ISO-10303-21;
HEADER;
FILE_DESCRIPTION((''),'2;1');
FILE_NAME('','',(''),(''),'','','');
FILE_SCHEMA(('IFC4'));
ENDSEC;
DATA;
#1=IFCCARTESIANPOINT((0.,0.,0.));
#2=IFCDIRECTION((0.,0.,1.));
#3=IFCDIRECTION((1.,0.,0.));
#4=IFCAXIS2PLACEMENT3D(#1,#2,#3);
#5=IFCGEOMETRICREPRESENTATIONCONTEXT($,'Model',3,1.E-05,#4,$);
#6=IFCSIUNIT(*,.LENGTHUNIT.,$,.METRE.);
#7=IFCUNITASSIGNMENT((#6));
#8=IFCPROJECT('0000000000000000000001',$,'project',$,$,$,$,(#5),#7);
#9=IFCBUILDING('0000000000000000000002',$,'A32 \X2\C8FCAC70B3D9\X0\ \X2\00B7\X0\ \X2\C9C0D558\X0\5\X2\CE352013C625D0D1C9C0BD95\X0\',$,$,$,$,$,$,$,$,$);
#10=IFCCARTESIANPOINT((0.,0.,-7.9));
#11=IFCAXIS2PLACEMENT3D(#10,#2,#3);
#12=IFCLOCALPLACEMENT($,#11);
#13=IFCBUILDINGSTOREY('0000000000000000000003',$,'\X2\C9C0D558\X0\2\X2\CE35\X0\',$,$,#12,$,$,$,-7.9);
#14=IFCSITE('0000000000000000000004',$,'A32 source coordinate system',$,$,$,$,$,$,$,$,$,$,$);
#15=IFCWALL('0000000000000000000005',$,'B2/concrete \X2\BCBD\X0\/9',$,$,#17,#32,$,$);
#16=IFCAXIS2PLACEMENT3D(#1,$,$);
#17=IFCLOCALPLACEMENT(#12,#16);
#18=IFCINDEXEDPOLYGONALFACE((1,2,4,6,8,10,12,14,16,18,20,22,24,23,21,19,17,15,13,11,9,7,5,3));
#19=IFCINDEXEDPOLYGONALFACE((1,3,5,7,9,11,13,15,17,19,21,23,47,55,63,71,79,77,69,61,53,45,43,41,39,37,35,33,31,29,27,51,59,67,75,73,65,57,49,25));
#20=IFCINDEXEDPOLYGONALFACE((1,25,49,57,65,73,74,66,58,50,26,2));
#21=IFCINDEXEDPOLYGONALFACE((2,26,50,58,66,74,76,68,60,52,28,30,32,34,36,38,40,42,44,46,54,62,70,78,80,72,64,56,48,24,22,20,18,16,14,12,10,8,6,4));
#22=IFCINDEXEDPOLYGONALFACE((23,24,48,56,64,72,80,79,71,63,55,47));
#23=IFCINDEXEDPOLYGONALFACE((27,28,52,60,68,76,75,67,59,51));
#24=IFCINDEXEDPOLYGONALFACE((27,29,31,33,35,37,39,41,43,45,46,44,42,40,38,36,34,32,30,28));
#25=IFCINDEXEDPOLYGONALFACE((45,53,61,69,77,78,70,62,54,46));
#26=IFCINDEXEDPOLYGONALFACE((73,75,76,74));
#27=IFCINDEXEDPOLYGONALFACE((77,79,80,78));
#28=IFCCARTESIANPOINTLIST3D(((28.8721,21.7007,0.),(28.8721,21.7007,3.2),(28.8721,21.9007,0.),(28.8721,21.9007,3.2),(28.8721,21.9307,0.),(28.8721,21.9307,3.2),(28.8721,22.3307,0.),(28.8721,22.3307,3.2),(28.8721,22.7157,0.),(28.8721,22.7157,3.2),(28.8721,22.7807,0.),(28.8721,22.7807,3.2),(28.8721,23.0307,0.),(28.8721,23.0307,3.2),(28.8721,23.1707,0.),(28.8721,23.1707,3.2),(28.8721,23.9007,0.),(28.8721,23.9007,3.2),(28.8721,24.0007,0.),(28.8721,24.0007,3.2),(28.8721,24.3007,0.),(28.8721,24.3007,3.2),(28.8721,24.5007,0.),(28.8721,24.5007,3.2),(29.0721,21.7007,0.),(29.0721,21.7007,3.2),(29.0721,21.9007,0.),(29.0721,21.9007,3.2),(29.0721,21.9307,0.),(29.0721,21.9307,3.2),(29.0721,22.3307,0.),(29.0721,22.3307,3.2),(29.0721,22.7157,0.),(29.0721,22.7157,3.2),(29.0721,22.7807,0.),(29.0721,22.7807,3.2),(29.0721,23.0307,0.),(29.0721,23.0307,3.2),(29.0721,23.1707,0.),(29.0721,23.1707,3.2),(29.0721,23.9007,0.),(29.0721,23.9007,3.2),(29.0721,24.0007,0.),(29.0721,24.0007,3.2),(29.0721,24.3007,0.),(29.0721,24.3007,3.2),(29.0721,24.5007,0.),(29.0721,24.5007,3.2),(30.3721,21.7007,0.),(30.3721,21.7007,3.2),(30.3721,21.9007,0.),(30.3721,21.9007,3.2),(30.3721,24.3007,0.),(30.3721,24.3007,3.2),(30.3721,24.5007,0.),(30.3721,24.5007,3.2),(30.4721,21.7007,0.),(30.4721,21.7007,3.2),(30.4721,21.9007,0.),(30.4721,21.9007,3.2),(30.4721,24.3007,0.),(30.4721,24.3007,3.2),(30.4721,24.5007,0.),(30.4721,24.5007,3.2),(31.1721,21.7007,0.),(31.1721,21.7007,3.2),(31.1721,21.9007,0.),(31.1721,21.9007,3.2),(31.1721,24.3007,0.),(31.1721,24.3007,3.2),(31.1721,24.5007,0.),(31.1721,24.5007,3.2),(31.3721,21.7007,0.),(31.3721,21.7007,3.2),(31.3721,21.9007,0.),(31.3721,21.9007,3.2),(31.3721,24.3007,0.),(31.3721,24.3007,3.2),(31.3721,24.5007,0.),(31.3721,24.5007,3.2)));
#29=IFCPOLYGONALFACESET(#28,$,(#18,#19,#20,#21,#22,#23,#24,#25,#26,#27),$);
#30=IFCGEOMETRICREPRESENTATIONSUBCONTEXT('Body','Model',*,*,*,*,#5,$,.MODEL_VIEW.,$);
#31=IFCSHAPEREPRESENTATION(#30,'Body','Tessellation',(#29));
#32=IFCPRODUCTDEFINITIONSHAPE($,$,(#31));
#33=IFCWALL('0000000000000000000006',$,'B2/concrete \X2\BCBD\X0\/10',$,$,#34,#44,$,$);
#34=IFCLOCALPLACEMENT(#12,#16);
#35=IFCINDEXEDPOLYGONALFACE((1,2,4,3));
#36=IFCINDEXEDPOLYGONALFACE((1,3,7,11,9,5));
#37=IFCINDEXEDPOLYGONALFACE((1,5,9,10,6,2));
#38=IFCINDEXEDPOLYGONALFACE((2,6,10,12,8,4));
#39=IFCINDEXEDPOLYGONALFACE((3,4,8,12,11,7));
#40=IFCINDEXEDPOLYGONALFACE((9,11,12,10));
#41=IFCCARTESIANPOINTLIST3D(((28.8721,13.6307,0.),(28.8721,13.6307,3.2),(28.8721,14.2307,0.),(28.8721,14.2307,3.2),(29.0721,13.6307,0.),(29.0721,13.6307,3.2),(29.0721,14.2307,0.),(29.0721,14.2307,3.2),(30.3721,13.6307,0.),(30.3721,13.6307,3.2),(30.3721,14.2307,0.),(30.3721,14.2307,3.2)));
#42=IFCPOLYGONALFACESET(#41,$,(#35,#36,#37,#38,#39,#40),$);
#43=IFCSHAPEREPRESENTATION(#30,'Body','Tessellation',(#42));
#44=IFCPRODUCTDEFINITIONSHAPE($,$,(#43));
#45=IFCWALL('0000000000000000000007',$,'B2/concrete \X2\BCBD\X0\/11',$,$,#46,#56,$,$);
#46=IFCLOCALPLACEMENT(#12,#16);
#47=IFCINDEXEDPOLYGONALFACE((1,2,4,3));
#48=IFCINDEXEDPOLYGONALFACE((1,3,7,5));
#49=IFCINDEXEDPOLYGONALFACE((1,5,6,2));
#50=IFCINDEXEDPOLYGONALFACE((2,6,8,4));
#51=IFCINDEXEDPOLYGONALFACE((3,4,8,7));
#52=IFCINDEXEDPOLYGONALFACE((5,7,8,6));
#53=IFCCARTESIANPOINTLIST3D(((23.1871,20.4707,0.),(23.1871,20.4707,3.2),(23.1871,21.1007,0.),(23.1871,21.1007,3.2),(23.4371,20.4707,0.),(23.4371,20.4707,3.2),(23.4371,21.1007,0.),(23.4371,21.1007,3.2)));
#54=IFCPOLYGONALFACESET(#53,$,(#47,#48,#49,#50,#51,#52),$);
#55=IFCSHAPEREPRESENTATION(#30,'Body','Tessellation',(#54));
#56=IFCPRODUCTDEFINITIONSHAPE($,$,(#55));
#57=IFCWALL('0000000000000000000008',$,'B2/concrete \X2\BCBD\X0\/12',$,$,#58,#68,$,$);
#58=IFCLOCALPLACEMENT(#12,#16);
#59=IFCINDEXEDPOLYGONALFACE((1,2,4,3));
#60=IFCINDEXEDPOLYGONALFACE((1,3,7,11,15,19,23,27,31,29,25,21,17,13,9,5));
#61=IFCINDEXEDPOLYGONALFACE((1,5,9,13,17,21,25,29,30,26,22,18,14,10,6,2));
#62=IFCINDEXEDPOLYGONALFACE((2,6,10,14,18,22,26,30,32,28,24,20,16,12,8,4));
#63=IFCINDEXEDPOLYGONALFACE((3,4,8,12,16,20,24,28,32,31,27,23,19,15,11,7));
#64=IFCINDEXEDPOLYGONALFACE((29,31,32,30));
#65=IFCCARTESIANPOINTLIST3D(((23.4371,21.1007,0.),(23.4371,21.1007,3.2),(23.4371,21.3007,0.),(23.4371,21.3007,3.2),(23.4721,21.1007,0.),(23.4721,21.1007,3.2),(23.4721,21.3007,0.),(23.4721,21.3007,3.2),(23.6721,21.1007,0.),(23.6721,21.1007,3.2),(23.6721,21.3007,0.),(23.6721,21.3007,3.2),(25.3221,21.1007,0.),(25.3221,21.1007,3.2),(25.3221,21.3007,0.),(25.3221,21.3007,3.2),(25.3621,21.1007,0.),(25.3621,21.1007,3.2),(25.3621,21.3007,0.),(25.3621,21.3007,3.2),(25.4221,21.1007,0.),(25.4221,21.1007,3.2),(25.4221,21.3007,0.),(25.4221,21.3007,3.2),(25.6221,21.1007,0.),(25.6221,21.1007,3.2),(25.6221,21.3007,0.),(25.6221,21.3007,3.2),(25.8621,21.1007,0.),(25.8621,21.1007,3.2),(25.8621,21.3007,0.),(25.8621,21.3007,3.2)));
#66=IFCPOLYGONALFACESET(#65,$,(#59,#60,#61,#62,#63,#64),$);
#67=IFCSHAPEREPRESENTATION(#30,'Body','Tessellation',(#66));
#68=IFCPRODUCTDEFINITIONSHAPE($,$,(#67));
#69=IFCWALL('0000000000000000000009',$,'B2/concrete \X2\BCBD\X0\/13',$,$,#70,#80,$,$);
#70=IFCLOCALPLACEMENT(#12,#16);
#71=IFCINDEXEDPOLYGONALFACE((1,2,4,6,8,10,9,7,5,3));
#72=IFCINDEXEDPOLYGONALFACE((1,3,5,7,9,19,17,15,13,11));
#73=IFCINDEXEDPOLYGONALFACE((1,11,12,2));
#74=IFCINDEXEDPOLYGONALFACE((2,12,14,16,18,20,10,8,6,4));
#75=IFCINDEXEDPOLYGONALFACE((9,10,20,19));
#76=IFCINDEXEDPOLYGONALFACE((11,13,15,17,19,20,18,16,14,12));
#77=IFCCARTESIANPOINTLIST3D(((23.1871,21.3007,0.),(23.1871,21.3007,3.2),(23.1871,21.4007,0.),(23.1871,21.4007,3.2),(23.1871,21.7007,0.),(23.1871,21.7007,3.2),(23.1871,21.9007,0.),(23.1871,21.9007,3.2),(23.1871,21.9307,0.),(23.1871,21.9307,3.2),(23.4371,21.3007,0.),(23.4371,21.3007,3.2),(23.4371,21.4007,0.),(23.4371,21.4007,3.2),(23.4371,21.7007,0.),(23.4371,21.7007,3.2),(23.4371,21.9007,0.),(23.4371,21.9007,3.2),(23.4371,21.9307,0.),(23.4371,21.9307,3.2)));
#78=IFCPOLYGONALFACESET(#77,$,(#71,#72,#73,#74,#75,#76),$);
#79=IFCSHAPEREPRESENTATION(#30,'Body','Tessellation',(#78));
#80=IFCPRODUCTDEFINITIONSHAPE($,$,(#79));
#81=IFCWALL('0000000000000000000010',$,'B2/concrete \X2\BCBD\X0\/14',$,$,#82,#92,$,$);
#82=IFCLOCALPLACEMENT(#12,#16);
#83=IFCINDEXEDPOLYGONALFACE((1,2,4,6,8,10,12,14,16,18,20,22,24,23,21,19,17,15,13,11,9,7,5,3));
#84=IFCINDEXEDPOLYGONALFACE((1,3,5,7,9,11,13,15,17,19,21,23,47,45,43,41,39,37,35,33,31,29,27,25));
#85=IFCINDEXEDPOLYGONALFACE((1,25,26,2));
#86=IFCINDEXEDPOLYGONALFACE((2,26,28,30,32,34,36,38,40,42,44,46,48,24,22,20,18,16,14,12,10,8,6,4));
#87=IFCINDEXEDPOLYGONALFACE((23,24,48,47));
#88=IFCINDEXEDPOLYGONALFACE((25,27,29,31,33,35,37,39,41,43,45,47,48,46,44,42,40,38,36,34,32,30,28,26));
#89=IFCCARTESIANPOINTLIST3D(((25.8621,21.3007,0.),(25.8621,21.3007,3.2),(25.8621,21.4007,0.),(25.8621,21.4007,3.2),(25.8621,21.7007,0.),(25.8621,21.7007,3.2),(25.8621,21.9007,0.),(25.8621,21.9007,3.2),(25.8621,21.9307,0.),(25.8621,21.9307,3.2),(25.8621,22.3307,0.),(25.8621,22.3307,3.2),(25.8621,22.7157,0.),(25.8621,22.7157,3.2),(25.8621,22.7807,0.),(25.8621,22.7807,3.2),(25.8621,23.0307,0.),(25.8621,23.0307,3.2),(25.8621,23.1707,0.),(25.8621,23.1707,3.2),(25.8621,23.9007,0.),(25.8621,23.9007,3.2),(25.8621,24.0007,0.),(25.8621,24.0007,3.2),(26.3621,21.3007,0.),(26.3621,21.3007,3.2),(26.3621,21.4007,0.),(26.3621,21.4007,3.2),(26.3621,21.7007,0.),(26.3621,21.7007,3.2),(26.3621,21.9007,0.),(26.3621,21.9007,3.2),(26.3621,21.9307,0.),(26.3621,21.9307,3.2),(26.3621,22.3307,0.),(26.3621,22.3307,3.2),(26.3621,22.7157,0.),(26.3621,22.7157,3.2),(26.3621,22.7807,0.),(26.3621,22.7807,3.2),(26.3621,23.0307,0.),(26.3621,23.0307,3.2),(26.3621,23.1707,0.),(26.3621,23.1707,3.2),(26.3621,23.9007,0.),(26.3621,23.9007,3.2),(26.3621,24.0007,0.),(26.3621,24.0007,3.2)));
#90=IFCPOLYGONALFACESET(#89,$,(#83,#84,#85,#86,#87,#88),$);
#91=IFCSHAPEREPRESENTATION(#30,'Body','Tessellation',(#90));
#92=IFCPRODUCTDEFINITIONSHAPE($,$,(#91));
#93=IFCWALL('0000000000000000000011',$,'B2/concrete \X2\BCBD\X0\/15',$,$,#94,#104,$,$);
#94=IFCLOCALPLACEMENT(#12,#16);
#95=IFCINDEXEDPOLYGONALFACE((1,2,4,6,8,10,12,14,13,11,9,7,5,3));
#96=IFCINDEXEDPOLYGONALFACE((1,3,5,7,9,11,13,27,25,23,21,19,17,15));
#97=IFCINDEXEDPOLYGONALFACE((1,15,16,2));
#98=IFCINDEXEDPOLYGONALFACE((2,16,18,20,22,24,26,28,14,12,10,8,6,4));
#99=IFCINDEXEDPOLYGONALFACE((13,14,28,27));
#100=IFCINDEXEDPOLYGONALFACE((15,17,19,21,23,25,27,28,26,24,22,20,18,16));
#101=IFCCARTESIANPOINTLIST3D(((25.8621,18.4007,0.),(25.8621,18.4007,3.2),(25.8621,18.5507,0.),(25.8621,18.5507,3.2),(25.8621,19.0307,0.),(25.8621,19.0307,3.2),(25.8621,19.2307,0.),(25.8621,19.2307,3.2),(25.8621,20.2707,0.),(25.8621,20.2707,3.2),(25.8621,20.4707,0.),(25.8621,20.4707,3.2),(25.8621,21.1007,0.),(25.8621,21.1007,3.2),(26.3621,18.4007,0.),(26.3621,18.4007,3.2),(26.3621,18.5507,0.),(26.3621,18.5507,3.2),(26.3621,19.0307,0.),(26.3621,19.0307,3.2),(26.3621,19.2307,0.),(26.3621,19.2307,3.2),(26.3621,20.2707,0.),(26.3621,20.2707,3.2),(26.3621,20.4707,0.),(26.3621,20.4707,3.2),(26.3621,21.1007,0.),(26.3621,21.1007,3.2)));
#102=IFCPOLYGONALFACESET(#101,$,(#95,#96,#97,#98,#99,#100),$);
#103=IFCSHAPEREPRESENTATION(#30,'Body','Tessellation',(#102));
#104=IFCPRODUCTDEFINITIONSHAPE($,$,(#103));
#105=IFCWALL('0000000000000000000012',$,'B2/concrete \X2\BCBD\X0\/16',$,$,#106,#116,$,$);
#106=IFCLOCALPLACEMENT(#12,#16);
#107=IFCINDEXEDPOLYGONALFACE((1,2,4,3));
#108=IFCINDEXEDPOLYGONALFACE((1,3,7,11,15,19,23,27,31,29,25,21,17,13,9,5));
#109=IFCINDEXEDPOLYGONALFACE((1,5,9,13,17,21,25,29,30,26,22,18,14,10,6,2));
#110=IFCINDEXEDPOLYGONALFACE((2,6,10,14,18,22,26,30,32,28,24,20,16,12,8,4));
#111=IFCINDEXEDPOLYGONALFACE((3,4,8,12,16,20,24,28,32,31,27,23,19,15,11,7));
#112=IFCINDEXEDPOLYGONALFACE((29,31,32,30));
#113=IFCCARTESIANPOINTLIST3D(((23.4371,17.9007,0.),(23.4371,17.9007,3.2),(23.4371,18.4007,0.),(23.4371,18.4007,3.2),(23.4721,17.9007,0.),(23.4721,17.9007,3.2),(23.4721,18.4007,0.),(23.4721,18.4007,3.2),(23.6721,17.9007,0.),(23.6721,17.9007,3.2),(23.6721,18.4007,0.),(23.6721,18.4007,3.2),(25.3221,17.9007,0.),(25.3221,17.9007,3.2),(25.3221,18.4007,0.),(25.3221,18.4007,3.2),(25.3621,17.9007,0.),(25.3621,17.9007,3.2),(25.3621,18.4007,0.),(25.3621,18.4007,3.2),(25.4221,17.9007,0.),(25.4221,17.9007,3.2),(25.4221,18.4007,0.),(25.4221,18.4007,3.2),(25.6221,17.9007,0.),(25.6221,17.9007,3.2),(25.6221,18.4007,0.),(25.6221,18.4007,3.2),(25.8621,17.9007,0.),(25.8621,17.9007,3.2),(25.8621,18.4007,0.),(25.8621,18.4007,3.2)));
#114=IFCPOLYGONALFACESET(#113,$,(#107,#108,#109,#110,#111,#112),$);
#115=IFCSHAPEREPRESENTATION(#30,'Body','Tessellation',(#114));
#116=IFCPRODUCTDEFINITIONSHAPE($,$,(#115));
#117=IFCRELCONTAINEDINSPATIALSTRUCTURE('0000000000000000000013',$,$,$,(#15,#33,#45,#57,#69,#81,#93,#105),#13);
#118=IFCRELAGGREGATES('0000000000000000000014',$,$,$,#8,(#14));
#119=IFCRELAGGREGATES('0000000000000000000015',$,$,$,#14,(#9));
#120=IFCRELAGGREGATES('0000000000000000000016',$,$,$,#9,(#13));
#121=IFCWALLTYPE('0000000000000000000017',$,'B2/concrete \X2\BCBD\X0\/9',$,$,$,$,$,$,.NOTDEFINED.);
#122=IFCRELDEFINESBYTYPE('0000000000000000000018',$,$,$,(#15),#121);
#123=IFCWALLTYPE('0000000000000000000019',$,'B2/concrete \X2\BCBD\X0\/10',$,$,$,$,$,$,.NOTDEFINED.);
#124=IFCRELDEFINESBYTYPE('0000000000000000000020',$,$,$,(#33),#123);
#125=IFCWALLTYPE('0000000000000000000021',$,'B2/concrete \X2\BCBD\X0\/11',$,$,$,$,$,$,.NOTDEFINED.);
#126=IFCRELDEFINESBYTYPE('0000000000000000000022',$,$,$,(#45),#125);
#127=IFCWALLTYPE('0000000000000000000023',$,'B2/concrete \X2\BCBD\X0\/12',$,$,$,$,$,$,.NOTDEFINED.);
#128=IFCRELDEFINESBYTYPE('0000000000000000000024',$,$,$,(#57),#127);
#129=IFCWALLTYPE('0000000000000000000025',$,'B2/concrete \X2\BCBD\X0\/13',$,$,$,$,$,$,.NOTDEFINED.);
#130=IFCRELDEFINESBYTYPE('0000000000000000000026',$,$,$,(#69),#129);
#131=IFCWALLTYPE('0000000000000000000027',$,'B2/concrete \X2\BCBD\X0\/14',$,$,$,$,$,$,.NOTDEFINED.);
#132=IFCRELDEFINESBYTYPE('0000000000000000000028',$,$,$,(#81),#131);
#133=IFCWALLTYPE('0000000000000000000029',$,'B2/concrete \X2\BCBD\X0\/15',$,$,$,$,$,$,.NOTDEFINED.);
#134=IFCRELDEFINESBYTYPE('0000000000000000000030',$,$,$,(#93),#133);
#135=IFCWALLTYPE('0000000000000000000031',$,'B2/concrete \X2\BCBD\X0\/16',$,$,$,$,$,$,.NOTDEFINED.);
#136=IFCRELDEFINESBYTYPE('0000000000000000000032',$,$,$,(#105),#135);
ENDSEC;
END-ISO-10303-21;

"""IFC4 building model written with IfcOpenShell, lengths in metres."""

from ifc_helpers import new_model, si_unit, frame, origin, origin_with_axes, place, context, subcontext, project, spatial, polyline, outline, extrude, source, transform, mapped, type_object, type_shapes, element, save


model = new_model("IFC4")

# Units and contexts
model_context = context("Model", 3, precision=1e-05, world=origin_with_axes())
body_context = subcontext(model_context, "Body", "Model", "MODEL_VIEW")
ifc_project = project(units=[si_unit("LENGTHUNIT", "METRE")], contexts=[model_context])

# Site, building, storey
site = spatial("IfcSite", under=ifc_project, Name="A32 source coordinate system")
building = spatial("IfcBuilding", under=site, Name="A32 주거동 · 지하5층–옥탑지붕")
storey_placement = place(None, frame((0.0, 0.0, -7.9), z_axis=(0.0, 0.0, 1.0), x_axis=(1.0, 0.0, 0.0)))
storey = spatial("IfcBuildingStorey", under=building, at=storey_placement, Name="지하2층", Elevation=-7.9)

# Walls
wall_type_1 = type_object("IfcWallType", Name="B2/concrete 벽/9", PredefinedType="NOTDEFINED")
shared_shape_1 = source(origin(), body_context, "Body", "SweptSolid", [
    extrude(outline(polyline([(28.8721, 24.3007), (28.8721, 24.5007), (29.0721, 24.5007), (30.3721, 24.5007), (30.4721, 24.5007), (31.1721, 24.5007), (31.3721, 24.5007), (31.3721, 24.3007), (31.1721, 24.3007), (30.4721, 24.3007), (30.3721, 24.3007), (29.0721, 24.3007), (29.0721, 24.0007), (29.0721, 23.9007), (29.0721, 23.1707), (29.0721, 23.0307), (29.0721, 22.7807), (29.0721, 22.7157), (29.0721, 22.3307), (29.0721, 21.9307), (29.0721, 21.9007), (30.3721, 21.9007), (30.4721, 21.9007), (31.1721, 21.9007), (31.3721, 21.9007), (31.3721, 21.7007), (31.1721, 21.7007), (30.4721, 21.7007), (30.3721, 21.7007), (29.0721, 21.7007), (28.8721, 21.7007), (28.8721, 21.9007), (28.8721, 21.9307), (28.8721, 22.3307), (28.8721, 22.7157), (28.8721, 22.7807), (28.8721, 23.0307), (28.8721, 23.1707), (28.8721, 23.9007), (28.8721, 24.0007), (28.8721, 24.3007)])), origin(), (0.0, 0.0, 1.0), 3.2),
])
type_shapes(wall_type_1, [shared_shape_1])
wall_1_placement = place(storey_placement, origin_with_axes())
element("IfcWall", 1, at=wall_1_placement, inside=storey, type_object=wall_type_1, Name="B2/concrete 벽/9", context=body_context, shape_type="MappedRepresentation", body=[
    mapped(shared_shape_1, transform((0.0, 0.0, 0.0), scale=1.0)),
])
wall_type_2 = type_object("IfcWallType", Name="B2/concrete 벽/10", PredefinedType="NOTDEFINED")
shared_shape_2 = source(origin(), body_context, "Body", "SweptSolid", [
    extrude(outline(polyline([(30.3721, 13.6307), (29.0721, 13.6307), (28.8721, 13.6307), (28.8721, 14.2307), (29.0721, 14.2307), (30.3721, 14.2307), (30.3721, 13.6307)])), origin(), (0.0, 0.0, 1.0), 3.2),
])
type_shapes(wall_type_2, [shared_shape_2])
wall_2_placement = place(storey_placement, origin_with_axes())
element("IfcWall", 2, at=wall_2_placement, inside=storey, type_object=wall_type_2, Name="B2/concrete 벽/10", context=body_context, shape_type="MappedRepresentation", body=[
    mapped(shared_shape_2, transform((0.0, 0.0, 0.0), scale=1.0)),
])
wall_type_3 = type_object("IfcWallType", Name="B2/concrete 벽/11", PredefinedType="NOTDEFINED")
shared_shape_3 = source(origin(), body_context, "Body", "SweptSolid", [
    extrude(outline(polyline([(23.1871, 20.4707), (23.1871, 21.1007), (23.4371, 21.1007), (23.4371, 20.4707), (23.1871, 20.4707)])), origin(), (0.0, 0.0, 1.0), 3.2),
])
type_shapes(wall_type_3, [shared_shape_3])
wall_3_placement = place(storey_placement, origin_with_axes())
element("IfcWall", 3, at=wall_3_placement, inside=storey, type_object=wall_type_3, Name="B2/concrete 벽/11", context=body_context, shape_type="MappedRepresentation", body=[
    mapped(shared_shape_3, transform((0.0, 0.0, 0.0), scale=1.0)),
])
wall_type_4 = type_object("IfcWallType", Name="B2/concrete 벽/12", PredefinedType="NOTDEFINED")
shared_shape_4 = source(origin(), body_context, "Body", "SweptSolid", [
    extrude(outline(polyline([(23.6721, 21.3007), (25.3221, 21.3007), (25.3621, 21.3007), (25.4221, 21.3007), (25.6221, 21.3007), (25.8621, 21.3007), (25.8621, 21.1007), (25.6221, 21.1007), (25.4221, 21.1007), (25.3621, 21.1007), (25.3221, 21.1007), (23.6721, 21.1007), (23.4721, 21.1007), (23.4371, 21.1007), (23.4371, 21.3007), (23.4721, 21.3007), (23.6721, 21.3007)])), origin(), (0.0, 0.0, 1.0), 3.2),
])
type_shapes(wall_type_4, [shared_shape_4])
wall_4_placement = place(storey_placement, origin_with_axes())
element("IfcWall", 4, at=wall_4_placement, inside=storey, type_object=wall_type_4, Name="B2/concrete 벽/12", context=body_context, shape_type="MappedRepresentation", body=[
    mapped(shared_shape_4, transform((0.0, 0.0, 0.0), scale=1.0)),
])
wall_type_5 = type_object("IfcWallType", Name="B2/concrete 벽/13", PredefinedType="NOTDEFINED")
shared_shape_5 = source(origin(), body_context, "Body", "SweptSolid", [
    extrude(outline(polyline([(23.1871, 21.7007), (23.1871, 21.9007), (23.1871, 21.9307), (23.4371, 21.9307), (23.4371, 21.9007), (23.4371, 21.7007), (23.4371, 21.4007), (23.4371, 21.3007), (23.1871, 21.3007), (23.1871, 21.4007), (23.1871, 21.7007)])), origin(), (0.0, 0.0, 1.0), 3.2),
])
type_shapes(wall_type_5, [shared_shape_5])
wall_5_placement = place(storey_placement, origin_with_axes())
element("IfcWall", 5, at=wall_5_placement, inside=storey, type_object=wall_type_5, Name="B2/concrete 벽/13", context=body_context, shape_type="MappedRepresentation", body=[
    mapped(shared_shape_5, transform((0.0, 0.0, 0.0), scale=1.0)),
])
wall_type_6 = type_object("IfcWallType", Name="B2/concrete 벽/14", PredefinedType="NOTDEFINED")
shared_shape_6 = source(origin(), body_context, "Body", "SweptSolid", [
    extrude(outline(polyline([(25.8621, 21.9007), (25.8621, 21.9307), (25.8621, 22.3307), (25.8621, 22.7157), (25.8621, 22.7807), (25.8621, 23.0307), (25.8621, 23.1707), (25.8621, 23.9007), (25.8621, 24.0007), (26.3621, 24.0007), (26.3621, 23.9007), (26.3621, 23.1707), (26.3621, 23.0307), (26.3621, 22.7807), (26.3621, 22.7157), (26.3621, 22.3307), (26.3621, 21.9307), (26.3621, 21.9007), (26.3621, 21.7007), (26.3621, 21.4007), (26.3621, 21.3007), (25.8621, 21.3007), (25.8621, 21.4007), (25.8621, 21.7007), (25.8621, 21.9007)])), origin(), (0.0, 0.0, 1.0), 3.2),
])
type_shapes(wall_type_6, [shared_shape_6])
wall_6_placement = place(storey_placement, origin_with_axes())
element("IfcWall", 6, at=wall_6_placement, inside=storey, type_object=wall_type_6, Name="B2/concrete 벽/14", context=body_context, shape_type="MappedRepresentation", body=[
    mapped(shared_shape_6, transform((0.0, 0.0, 0.0), scale=1.0)),
])
wall_type_7 = type_object("IfcWallType", Name="B2/concrete 벽/15", PredefinedType="NOTDEFINED")
shared_shape_7 = source(origin(), body_context, "Body", "SweptSolid", [
    extrude(outline(polyline([(26.3621, 20.2707), (26.3621, 19.2307), (26.3621, 19.0307), (26.3621, 18.5507), (26.3621, 18.4007), (25.8621, 18.4007), (25.8621, 18.5507), (25.8621, 19.0307), (25.8621, 19.2307), (25.8621, 20.2707), (25.8621, 20.4707), (25.8621, 21.1007), (26.3621, 21.1007), (26.3621, 20.4707), (26.3621, 20.2707)])), origin(), (0.0, 0.0, 1.0), 3.2),
])
type_shapes(wall_type_7, [shared_shape_7])
wall_7_placement = place(storey_placement, origin_with_axes())
element("IfcWall", 7, at=wall_7_placement, inside=storey, type_object=wall_type_7, Name="B2/concrete 벽/15", context=body_context, shape_type="MappedRepresentation", body=[
    mapped(shared_shape_7, transform((0.0, 0.0, 0.0), scale=1.0)),
])
wall_type_8 = type_object("IfcWallType", Name="B2/concrete 벽/16", PredefinedType="NOTDEFINED")
shared_shape_8 = source(origin(), body_context, "Body", "SweptSolid", [
    extrude(outline(polyline([(25.4221, 17.9007), (25.3621, 17.9007), (25.3221, 17.9007), (23.6721, 17.9007), (23.4721, 17.9007), (23.4371, 17.9007), (23.4371, 18.4007), (23.4721, 18.4007), (23.6721, 18.4007), (25.3221, 18.4007), (25.3621, 18.4007), (25.4221, 18.4007), (25.6221, 18.4007), (25.8621, 18.4007), (25.8621, 17.9007), (25.6221, 17.9007), (25.4221, 17.9007)])), origin(), (0.0, 0.0, 1.0), 3.2),
])
type_shapes(wall_type_8, [shared_shape_8])
wall_8_placement = place(storey_placement, origin_with_axes())
element("IfcWall", 8, at=wall_8_placement, inside=storey, type_object=wall_type_8, Name="B2/concrete 벽/16", context=body_context, shape_type="MappedRepresentation", body=[
    mapped(shared_shape_8, transform((0.0, 0.0, 0.0), scale=1.0)),
])

save(model, "model.ifc")
